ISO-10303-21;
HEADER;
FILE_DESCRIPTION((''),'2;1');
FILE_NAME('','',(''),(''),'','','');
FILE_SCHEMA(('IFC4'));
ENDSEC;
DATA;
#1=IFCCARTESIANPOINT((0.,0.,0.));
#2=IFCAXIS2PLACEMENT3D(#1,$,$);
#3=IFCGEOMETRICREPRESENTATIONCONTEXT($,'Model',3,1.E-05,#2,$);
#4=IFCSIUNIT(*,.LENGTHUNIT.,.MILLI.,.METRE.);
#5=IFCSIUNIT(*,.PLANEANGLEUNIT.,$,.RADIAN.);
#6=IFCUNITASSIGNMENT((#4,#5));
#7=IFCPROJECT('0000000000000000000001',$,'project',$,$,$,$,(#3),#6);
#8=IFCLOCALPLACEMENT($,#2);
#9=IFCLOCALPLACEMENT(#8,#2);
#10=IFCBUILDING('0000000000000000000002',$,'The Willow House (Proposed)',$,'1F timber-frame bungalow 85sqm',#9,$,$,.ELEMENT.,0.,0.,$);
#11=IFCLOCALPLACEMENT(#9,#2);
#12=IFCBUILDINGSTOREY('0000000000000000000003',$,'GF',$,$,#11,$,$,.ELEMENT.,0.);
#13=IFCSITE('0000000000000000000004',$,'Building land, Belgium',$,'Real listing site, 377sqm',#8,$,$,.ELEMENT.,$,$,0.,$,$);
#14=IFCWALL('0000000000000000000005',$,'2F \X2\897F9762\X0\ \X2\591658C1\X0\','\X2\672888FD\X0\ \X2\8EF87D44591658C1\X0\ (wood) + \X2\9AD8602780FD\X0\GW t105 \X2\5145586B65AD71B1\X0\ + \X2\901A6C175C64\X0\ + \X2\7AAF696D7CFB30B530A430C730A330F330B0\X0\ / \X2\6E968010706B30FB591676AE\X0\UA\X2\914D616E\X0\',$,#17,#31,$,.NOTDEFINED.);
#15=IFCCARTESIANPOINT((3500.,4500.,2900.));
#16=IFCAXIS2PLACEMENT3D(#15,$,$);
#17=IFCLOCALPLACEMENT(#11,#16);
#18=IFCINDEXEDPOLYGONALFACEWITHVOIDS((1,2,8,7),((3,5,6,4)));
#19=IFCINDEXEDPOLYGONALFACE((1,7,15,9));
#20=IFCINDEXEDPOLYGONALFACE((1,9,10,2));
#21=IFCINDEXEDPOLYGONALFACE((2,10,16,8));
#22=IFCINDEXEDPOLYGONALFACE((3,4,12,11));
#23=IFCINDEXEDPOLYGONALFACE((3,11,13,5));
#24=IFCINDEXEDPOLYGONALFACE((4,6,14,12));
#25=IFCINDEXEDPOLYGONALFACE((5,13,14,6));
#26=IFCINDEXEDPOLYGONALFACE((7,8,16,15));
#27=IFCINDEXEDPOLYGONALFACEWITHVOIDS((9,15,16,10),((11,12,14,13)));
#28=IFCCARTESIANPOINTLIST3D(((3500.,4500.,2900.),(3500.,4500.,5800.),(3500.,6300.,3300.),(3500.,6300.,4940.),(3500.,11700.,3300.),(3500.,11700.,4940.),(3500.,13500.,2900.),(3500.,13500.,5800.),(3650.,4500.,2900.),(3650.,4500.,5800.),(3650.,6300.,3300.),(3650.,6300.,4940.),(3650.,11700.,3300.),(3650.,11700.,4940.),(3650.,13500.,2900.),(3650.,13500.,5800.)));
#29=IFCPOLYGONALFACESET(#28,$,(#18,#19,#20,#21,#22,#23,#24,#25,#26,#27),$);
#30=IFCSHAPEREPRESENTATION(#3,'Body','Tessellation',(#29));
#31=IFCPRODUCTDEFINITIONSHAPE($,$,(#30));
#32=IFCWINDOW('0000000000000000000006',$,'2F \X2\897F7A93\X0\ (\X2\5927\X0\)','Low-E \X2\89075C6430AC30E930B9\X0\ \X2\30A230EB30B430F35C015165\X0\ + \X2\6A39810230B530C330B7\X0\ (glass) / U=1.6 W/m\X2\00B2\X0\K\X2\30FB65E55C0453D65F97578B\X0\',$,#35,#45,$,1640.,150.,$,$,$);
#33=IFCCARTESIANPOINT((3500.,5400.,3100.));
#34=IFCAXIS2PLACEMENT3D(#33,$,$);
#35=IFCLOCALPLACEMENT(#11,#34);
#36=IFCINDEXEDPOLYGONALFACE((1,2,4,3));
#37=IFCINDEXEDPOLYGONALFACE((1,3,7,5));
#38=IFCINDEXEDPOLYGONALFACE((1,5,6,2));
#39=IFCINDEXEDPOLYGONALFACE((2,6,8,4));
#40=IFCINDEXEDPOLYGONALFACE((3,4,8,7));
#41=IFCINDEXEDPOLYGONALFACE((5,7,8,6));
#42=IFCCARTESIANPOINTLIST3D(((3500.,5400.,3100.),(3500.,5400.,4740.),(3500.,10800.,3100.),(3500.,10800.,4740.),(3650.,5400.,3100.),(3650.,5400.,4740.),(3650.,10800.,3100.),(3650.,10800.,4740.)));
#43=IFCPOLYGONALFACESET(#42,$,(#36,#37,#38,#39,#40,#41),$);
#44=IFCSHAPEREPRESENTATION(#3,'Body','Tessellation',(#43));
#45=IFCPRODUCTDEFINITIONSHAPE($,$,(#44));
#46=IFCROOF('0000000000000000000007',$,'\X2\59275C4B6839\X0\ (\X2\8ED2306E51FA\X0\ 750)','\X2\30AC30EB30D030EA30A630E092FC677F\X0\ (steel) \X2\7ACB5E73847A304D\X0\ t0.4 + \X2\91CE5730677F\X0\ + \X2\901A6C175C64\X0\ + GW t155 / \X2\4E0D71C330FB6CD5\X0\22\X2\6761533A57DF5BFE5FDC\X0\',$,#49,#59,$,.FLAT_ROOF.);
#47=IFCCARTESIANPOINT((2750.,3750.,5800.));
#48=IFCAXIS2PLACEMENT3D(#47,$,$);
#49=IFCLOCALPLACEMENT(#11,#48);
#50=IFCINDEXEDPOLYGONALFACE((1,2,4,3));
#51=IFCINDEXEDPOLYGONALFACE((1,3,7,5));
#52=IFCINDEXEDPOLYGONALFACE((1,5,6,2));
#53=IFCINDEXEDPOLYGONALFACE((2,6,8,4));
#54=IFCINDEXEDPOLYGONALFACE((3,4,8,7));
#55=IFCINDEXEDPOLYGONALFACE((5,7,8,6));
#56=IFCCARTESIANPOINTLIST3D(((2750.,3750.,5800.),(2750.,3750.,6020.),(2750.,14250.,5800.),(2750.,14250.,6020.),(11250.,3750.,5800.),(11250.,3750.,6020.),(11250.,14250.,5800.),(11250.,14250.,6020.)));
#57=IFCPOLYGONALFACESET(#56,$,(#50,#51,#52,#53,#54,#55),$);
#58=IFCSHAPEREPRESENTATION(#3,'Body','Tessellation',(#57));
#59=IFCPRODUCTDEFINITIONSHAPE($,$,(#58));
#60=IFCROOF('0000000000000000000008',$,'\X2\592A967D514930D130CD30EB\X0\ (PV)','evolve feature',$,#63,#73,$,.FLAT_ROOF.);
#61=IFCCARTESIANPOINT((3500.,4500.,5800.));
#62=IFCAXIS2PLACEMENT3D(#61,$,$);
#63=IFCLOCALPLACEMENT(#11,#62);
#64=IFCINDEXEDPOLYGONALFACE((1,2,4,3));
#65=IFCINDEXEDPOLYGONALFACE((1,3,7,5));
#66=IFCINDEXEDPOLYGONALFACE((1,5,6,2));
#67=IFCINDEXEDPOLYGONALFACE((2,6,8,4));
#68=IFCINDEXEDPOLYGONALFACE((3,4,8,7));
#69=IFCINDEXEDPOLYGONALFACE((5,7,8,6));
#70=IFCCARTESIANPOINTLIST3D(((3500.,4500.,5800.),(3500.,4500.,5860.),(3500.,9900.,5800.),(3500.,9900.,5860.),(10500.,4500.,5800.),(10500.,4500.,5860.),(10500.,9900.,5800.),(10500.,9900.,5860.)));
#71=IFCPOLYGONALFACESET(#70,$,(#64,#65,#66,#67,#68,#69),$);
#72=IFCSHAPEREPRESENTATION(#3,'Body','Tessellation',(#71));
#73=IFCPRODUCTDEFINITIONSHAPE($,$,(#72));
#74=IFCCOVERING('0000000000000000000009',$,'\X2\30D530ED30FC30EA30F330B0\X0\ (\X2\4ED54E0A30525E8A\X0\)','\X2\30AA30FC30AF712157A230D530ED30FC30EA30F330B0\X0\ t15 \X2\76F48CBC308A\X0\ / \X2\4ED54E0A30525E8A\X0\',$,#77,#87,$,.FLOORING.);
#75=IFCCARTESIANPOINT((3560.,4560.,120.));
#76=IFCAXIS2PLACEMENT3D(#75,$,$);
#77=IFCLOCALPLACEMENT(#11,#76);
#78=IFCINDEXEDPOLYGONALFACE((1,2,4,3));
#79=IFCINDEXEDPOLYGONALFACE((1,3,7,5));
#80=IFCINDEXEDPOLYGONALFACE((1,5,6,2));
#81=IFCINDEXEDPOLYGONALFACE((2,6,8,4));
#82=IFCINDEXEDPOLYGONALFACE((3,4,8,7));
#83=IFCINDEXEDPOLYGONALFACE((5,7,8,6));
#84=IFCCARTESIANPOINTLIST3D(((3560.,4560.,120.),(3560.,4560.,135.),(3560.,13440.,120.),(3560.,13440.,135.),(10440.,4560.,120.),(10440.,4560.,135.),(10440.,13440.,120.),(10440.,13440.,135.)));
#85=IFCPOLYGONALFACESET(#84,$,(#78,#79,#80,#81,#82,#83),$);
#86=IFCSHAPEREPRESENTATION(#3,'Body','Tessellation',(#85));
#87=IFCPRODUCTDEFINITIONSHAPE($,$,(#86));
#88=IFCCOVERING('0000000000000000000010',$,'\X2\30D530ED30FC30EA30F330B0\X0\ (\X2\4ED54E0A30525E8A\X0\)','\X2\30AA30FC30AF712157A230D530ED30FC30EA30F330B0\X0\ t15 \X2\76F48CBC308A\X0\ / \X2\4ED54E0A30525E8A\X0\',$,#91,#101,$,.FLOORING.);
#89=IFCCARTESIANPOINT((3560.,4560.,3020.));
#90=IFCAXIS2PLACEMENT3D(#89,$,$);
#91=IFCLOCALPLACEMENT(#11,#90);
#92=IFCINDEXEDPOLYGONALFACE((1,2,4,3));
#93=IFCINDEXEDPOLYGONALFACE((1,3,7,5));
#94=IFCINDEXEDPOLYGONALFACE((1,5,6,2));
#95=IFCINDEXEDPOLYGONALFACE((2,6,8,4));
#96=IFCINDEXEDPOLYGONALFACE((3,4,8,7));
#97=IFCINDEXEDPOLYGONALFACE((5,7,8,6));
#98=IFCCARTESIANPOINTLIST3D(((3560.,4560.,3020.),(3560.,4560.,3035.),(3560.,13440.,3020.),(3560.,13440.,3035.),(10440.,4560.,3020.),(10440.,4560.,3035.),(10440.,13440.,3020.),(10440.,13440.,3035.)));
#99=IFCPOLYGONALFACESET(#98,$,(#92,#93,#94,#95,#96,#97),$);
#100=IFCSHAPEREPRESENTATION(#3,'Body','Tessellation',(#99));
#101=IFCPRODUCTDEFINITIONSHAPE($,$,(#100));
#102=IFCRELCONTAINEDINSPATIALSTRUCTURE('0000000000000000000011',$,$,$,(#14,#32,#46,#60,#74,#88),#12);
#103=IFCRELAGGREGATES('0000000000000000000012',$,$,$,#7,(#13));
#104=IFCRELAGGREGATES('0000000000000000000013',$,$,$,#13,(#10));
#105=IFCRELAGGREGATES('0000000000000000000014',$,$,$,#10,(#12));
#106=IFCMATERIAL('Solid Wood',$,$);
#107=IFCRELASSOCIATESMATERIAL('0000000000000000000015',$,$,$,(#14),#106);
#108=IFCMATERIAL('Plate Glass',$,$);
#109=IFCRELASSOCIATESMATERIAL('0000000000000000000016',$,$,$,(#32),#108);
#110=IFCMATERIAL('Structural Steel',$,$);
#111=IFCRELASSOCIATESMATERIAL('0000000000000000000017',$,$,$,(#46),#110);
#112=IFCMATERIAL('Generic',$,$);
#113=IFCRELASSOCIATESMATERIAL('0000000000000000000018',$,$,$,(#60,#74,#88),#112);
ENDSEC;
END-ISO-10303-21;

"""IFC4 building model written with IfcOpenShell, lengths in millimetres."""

from ifc_helpers import new_model, si_unit, frame, frame_2d, origin, place, context, project, spatial, rectangle, extrude, material, element, fill, save


model = new_model("IFC4")

# Units and contexts
model_context = context("Model", 3, precision=1e-05, world=origin())
ifc_project = project(units=[si_unit("LENGTHUNIT", "METRE", prefix="MILLI"), si_unit("PLANEANGLEUNIT", "RADIAN")], contexts=[model_context])

# Site, building, storey
site_placement = place(None, origin())
site = spatial("IfcSite", under=ifc_project, at=site_placement, Name="Building land, Belgium", ObjectType="Real listing site, 377sqm", CompositionType="ELEMENT", RefElevation=0.0)
building_placement = place(site_placement, origin())
building = spatial("IfcBuilding", under=site, at=building_placement, Name="The Willow House (Proposed)", ObjectType="1F timber-frame bungalow 85sqm", CompositionType="ELEMENT", ElevationOfRefHeight=0.0, ElevationOfTerrain=0.0)
storey_placement = place(building_placement, origin())
storey = spatial("IfcBuildingStorey", under=building, at=storey_placement, Name="GF", CompositionType="ELEMENT", Elevation=0.0)

# Shared definitions
ifc_material_1 = material(Name="Solid Wood")
ifc_material_2 = material(Name="Generic")

# Shared definitions
ifc_material_3 = material(Name="Plate Glass")

# Wall, opening, window
wall_1_placement = place(storey_placement, frame((3500.0, 4500.0, 2900.0)))
wall_1 = element("IfcWall", 1, at=wall_1_placement, inside=storey, material=ifc_material_1, Name="2F 西面 外壁", Description="木製 軸組外壁 (wood) + 高性能GW t105 充填断熱 + 通気層 + 窯業系サイディング / 準耐火・外皮UA配慮", PredefinedType="NOTDEFINED", context=model_context, shape_type="SweptSolid", body=[
    extrude(rectangle(XDim=150.0, YDim=9000.0, at=frame_2d((75.0, 4500.0))), frame((3500.0, 4500.0, 2900.0)), (0.0, 0.0, 1.0), 2900.0),
])
opening_1_placement = place(storey_placement, frame((3500.0, 5400.0, 3100.0)))
opening_1 = element("IfcOpeningElement", 2, at=opening_1_placement, cuts=wall_1, PredefinedType="NOTDEFINED", context=model_context, shape_type="SweptSolid", body=[
    extrude(rectangle(XDim=150.0, YDim=5400.0, at=frame_2d((75.0, 2700.0))), frame((3500.0, 5400.0, 3100.0)), (0.0, 0.0, 1.0), 1640.0),
])
window_1_placement = place(storey_placement, frame((3500.0, 5400.0, 3100.0)))
window_1 = element("IfcWindow", 3, at=window_1_placement, inside=storey, material=ifc_material_3, Name="2F 西窓 (大)", Description="Low-E 複層ガラス アルゴン封入 + 樹脂サッシ (glass) / U=1.6 W/m²K・日射取得型", OverallHeight=1640.0, OverallWidth=150.0, context=model_context, shape_type="SweptSolid", body=[
    extrude(rectangle(XDim=150.0, YDim=5400.0, at=frame_2d((75.0, 2700.0))), frame((3500.0, 5400.0, 3100.0)), (0.0, 0.0, 1.0), 1640.0),
])
fill(opening_1, window_1)

# Roofs
ifc_material_4 = material(Name="Structural Steel")
roof_1_placement = place(storey_placement, frame((2750.0, 3750.0, 5800.0)))
element("IfcRoof", 4, at=roof_1_placement, inside=storey, material=ifc_material_4, Name="大屋根 (軒の出 750)", Description="ガルバリウム鋼板 (steel) 立平葺き t0.4 + 野地板 + 通気層 + GW t155 / 不燃・法22条区域対応", PredefinedType="FLAT_ROOF", context=model_context, shape_type="SweptSolid", body=[
    extrude(rectangle(XDim=8500.0, YDim=10500.0, at=frame_2d((4250.0, 5250.0))), frame((2750.0, 3750.0, 5800.0)), (0.0, 0.0, 1.0), 220.0),
])
roof_2_placement = place(storey_placement, frame((3500.0, 4500.0, 5800.0)))
element("IfcRoof", 5, at=roof_2_placement, inside=storey, material=ifc_material_2, Name="太陽光パネル (PV)", Description="evolve feature", PredefinedType="FLAT_ROOF", context=model_context, shape_type="SweptSolid", body=[
    extrude(rectangle(XDim=7000.0, YDim=5400.0, at=frame_2d((3500.0, 2700.0))), frame((3500.0, 4500.0, 5800.0)), (0.0, 0.0, 1.0), 60.0),
])

# Coverings
covering_1_placement = place(storey_placement, frame((3560.0, 4560.0, 120.0)))
element("IfcCovering", 6, at=covering_1_placement, inside=storey, material=ifc_material_2, Name="フローリング (仕上げ床)", Description="オーク無垢フローリング t15 直貼り / 仕上げ床", PredefinedType="FLOORING", context=model_context, shape_type="SweptSolid", body=[
    extrude(rectangle(XDim=6880.0, YDim=8880.0, at=frame_2d((3440.0, 4440.0))), frame((3560.0, 4560.0, 120.0)), (0.0, 0.0, 1.0), 15.0),
])
covering_2_placement = place(storey_placement, frame((3560.0, 4560.0, 3020.0)))
element("IfcCovering", 7, at=covering_2_placement, inside=storey, material=ifc_material_2, Name="フローリング (仕上げ床)", Description="オーク無垢フローリング t15 直貼り / 仕上げ床", PredefinedType="FLOORING", context=model_context, shape_type="SweptSolid", body=[
    extrude(rectangle(XDim=6880.0, YDim=8880.0, at=frame_2d((3440.0, 4440.0))), frame((3560.0, 4560.0, 3020.0)), (0.0, 0.0, 1.0), 15.0),
])

save(model, "model.ifc")
